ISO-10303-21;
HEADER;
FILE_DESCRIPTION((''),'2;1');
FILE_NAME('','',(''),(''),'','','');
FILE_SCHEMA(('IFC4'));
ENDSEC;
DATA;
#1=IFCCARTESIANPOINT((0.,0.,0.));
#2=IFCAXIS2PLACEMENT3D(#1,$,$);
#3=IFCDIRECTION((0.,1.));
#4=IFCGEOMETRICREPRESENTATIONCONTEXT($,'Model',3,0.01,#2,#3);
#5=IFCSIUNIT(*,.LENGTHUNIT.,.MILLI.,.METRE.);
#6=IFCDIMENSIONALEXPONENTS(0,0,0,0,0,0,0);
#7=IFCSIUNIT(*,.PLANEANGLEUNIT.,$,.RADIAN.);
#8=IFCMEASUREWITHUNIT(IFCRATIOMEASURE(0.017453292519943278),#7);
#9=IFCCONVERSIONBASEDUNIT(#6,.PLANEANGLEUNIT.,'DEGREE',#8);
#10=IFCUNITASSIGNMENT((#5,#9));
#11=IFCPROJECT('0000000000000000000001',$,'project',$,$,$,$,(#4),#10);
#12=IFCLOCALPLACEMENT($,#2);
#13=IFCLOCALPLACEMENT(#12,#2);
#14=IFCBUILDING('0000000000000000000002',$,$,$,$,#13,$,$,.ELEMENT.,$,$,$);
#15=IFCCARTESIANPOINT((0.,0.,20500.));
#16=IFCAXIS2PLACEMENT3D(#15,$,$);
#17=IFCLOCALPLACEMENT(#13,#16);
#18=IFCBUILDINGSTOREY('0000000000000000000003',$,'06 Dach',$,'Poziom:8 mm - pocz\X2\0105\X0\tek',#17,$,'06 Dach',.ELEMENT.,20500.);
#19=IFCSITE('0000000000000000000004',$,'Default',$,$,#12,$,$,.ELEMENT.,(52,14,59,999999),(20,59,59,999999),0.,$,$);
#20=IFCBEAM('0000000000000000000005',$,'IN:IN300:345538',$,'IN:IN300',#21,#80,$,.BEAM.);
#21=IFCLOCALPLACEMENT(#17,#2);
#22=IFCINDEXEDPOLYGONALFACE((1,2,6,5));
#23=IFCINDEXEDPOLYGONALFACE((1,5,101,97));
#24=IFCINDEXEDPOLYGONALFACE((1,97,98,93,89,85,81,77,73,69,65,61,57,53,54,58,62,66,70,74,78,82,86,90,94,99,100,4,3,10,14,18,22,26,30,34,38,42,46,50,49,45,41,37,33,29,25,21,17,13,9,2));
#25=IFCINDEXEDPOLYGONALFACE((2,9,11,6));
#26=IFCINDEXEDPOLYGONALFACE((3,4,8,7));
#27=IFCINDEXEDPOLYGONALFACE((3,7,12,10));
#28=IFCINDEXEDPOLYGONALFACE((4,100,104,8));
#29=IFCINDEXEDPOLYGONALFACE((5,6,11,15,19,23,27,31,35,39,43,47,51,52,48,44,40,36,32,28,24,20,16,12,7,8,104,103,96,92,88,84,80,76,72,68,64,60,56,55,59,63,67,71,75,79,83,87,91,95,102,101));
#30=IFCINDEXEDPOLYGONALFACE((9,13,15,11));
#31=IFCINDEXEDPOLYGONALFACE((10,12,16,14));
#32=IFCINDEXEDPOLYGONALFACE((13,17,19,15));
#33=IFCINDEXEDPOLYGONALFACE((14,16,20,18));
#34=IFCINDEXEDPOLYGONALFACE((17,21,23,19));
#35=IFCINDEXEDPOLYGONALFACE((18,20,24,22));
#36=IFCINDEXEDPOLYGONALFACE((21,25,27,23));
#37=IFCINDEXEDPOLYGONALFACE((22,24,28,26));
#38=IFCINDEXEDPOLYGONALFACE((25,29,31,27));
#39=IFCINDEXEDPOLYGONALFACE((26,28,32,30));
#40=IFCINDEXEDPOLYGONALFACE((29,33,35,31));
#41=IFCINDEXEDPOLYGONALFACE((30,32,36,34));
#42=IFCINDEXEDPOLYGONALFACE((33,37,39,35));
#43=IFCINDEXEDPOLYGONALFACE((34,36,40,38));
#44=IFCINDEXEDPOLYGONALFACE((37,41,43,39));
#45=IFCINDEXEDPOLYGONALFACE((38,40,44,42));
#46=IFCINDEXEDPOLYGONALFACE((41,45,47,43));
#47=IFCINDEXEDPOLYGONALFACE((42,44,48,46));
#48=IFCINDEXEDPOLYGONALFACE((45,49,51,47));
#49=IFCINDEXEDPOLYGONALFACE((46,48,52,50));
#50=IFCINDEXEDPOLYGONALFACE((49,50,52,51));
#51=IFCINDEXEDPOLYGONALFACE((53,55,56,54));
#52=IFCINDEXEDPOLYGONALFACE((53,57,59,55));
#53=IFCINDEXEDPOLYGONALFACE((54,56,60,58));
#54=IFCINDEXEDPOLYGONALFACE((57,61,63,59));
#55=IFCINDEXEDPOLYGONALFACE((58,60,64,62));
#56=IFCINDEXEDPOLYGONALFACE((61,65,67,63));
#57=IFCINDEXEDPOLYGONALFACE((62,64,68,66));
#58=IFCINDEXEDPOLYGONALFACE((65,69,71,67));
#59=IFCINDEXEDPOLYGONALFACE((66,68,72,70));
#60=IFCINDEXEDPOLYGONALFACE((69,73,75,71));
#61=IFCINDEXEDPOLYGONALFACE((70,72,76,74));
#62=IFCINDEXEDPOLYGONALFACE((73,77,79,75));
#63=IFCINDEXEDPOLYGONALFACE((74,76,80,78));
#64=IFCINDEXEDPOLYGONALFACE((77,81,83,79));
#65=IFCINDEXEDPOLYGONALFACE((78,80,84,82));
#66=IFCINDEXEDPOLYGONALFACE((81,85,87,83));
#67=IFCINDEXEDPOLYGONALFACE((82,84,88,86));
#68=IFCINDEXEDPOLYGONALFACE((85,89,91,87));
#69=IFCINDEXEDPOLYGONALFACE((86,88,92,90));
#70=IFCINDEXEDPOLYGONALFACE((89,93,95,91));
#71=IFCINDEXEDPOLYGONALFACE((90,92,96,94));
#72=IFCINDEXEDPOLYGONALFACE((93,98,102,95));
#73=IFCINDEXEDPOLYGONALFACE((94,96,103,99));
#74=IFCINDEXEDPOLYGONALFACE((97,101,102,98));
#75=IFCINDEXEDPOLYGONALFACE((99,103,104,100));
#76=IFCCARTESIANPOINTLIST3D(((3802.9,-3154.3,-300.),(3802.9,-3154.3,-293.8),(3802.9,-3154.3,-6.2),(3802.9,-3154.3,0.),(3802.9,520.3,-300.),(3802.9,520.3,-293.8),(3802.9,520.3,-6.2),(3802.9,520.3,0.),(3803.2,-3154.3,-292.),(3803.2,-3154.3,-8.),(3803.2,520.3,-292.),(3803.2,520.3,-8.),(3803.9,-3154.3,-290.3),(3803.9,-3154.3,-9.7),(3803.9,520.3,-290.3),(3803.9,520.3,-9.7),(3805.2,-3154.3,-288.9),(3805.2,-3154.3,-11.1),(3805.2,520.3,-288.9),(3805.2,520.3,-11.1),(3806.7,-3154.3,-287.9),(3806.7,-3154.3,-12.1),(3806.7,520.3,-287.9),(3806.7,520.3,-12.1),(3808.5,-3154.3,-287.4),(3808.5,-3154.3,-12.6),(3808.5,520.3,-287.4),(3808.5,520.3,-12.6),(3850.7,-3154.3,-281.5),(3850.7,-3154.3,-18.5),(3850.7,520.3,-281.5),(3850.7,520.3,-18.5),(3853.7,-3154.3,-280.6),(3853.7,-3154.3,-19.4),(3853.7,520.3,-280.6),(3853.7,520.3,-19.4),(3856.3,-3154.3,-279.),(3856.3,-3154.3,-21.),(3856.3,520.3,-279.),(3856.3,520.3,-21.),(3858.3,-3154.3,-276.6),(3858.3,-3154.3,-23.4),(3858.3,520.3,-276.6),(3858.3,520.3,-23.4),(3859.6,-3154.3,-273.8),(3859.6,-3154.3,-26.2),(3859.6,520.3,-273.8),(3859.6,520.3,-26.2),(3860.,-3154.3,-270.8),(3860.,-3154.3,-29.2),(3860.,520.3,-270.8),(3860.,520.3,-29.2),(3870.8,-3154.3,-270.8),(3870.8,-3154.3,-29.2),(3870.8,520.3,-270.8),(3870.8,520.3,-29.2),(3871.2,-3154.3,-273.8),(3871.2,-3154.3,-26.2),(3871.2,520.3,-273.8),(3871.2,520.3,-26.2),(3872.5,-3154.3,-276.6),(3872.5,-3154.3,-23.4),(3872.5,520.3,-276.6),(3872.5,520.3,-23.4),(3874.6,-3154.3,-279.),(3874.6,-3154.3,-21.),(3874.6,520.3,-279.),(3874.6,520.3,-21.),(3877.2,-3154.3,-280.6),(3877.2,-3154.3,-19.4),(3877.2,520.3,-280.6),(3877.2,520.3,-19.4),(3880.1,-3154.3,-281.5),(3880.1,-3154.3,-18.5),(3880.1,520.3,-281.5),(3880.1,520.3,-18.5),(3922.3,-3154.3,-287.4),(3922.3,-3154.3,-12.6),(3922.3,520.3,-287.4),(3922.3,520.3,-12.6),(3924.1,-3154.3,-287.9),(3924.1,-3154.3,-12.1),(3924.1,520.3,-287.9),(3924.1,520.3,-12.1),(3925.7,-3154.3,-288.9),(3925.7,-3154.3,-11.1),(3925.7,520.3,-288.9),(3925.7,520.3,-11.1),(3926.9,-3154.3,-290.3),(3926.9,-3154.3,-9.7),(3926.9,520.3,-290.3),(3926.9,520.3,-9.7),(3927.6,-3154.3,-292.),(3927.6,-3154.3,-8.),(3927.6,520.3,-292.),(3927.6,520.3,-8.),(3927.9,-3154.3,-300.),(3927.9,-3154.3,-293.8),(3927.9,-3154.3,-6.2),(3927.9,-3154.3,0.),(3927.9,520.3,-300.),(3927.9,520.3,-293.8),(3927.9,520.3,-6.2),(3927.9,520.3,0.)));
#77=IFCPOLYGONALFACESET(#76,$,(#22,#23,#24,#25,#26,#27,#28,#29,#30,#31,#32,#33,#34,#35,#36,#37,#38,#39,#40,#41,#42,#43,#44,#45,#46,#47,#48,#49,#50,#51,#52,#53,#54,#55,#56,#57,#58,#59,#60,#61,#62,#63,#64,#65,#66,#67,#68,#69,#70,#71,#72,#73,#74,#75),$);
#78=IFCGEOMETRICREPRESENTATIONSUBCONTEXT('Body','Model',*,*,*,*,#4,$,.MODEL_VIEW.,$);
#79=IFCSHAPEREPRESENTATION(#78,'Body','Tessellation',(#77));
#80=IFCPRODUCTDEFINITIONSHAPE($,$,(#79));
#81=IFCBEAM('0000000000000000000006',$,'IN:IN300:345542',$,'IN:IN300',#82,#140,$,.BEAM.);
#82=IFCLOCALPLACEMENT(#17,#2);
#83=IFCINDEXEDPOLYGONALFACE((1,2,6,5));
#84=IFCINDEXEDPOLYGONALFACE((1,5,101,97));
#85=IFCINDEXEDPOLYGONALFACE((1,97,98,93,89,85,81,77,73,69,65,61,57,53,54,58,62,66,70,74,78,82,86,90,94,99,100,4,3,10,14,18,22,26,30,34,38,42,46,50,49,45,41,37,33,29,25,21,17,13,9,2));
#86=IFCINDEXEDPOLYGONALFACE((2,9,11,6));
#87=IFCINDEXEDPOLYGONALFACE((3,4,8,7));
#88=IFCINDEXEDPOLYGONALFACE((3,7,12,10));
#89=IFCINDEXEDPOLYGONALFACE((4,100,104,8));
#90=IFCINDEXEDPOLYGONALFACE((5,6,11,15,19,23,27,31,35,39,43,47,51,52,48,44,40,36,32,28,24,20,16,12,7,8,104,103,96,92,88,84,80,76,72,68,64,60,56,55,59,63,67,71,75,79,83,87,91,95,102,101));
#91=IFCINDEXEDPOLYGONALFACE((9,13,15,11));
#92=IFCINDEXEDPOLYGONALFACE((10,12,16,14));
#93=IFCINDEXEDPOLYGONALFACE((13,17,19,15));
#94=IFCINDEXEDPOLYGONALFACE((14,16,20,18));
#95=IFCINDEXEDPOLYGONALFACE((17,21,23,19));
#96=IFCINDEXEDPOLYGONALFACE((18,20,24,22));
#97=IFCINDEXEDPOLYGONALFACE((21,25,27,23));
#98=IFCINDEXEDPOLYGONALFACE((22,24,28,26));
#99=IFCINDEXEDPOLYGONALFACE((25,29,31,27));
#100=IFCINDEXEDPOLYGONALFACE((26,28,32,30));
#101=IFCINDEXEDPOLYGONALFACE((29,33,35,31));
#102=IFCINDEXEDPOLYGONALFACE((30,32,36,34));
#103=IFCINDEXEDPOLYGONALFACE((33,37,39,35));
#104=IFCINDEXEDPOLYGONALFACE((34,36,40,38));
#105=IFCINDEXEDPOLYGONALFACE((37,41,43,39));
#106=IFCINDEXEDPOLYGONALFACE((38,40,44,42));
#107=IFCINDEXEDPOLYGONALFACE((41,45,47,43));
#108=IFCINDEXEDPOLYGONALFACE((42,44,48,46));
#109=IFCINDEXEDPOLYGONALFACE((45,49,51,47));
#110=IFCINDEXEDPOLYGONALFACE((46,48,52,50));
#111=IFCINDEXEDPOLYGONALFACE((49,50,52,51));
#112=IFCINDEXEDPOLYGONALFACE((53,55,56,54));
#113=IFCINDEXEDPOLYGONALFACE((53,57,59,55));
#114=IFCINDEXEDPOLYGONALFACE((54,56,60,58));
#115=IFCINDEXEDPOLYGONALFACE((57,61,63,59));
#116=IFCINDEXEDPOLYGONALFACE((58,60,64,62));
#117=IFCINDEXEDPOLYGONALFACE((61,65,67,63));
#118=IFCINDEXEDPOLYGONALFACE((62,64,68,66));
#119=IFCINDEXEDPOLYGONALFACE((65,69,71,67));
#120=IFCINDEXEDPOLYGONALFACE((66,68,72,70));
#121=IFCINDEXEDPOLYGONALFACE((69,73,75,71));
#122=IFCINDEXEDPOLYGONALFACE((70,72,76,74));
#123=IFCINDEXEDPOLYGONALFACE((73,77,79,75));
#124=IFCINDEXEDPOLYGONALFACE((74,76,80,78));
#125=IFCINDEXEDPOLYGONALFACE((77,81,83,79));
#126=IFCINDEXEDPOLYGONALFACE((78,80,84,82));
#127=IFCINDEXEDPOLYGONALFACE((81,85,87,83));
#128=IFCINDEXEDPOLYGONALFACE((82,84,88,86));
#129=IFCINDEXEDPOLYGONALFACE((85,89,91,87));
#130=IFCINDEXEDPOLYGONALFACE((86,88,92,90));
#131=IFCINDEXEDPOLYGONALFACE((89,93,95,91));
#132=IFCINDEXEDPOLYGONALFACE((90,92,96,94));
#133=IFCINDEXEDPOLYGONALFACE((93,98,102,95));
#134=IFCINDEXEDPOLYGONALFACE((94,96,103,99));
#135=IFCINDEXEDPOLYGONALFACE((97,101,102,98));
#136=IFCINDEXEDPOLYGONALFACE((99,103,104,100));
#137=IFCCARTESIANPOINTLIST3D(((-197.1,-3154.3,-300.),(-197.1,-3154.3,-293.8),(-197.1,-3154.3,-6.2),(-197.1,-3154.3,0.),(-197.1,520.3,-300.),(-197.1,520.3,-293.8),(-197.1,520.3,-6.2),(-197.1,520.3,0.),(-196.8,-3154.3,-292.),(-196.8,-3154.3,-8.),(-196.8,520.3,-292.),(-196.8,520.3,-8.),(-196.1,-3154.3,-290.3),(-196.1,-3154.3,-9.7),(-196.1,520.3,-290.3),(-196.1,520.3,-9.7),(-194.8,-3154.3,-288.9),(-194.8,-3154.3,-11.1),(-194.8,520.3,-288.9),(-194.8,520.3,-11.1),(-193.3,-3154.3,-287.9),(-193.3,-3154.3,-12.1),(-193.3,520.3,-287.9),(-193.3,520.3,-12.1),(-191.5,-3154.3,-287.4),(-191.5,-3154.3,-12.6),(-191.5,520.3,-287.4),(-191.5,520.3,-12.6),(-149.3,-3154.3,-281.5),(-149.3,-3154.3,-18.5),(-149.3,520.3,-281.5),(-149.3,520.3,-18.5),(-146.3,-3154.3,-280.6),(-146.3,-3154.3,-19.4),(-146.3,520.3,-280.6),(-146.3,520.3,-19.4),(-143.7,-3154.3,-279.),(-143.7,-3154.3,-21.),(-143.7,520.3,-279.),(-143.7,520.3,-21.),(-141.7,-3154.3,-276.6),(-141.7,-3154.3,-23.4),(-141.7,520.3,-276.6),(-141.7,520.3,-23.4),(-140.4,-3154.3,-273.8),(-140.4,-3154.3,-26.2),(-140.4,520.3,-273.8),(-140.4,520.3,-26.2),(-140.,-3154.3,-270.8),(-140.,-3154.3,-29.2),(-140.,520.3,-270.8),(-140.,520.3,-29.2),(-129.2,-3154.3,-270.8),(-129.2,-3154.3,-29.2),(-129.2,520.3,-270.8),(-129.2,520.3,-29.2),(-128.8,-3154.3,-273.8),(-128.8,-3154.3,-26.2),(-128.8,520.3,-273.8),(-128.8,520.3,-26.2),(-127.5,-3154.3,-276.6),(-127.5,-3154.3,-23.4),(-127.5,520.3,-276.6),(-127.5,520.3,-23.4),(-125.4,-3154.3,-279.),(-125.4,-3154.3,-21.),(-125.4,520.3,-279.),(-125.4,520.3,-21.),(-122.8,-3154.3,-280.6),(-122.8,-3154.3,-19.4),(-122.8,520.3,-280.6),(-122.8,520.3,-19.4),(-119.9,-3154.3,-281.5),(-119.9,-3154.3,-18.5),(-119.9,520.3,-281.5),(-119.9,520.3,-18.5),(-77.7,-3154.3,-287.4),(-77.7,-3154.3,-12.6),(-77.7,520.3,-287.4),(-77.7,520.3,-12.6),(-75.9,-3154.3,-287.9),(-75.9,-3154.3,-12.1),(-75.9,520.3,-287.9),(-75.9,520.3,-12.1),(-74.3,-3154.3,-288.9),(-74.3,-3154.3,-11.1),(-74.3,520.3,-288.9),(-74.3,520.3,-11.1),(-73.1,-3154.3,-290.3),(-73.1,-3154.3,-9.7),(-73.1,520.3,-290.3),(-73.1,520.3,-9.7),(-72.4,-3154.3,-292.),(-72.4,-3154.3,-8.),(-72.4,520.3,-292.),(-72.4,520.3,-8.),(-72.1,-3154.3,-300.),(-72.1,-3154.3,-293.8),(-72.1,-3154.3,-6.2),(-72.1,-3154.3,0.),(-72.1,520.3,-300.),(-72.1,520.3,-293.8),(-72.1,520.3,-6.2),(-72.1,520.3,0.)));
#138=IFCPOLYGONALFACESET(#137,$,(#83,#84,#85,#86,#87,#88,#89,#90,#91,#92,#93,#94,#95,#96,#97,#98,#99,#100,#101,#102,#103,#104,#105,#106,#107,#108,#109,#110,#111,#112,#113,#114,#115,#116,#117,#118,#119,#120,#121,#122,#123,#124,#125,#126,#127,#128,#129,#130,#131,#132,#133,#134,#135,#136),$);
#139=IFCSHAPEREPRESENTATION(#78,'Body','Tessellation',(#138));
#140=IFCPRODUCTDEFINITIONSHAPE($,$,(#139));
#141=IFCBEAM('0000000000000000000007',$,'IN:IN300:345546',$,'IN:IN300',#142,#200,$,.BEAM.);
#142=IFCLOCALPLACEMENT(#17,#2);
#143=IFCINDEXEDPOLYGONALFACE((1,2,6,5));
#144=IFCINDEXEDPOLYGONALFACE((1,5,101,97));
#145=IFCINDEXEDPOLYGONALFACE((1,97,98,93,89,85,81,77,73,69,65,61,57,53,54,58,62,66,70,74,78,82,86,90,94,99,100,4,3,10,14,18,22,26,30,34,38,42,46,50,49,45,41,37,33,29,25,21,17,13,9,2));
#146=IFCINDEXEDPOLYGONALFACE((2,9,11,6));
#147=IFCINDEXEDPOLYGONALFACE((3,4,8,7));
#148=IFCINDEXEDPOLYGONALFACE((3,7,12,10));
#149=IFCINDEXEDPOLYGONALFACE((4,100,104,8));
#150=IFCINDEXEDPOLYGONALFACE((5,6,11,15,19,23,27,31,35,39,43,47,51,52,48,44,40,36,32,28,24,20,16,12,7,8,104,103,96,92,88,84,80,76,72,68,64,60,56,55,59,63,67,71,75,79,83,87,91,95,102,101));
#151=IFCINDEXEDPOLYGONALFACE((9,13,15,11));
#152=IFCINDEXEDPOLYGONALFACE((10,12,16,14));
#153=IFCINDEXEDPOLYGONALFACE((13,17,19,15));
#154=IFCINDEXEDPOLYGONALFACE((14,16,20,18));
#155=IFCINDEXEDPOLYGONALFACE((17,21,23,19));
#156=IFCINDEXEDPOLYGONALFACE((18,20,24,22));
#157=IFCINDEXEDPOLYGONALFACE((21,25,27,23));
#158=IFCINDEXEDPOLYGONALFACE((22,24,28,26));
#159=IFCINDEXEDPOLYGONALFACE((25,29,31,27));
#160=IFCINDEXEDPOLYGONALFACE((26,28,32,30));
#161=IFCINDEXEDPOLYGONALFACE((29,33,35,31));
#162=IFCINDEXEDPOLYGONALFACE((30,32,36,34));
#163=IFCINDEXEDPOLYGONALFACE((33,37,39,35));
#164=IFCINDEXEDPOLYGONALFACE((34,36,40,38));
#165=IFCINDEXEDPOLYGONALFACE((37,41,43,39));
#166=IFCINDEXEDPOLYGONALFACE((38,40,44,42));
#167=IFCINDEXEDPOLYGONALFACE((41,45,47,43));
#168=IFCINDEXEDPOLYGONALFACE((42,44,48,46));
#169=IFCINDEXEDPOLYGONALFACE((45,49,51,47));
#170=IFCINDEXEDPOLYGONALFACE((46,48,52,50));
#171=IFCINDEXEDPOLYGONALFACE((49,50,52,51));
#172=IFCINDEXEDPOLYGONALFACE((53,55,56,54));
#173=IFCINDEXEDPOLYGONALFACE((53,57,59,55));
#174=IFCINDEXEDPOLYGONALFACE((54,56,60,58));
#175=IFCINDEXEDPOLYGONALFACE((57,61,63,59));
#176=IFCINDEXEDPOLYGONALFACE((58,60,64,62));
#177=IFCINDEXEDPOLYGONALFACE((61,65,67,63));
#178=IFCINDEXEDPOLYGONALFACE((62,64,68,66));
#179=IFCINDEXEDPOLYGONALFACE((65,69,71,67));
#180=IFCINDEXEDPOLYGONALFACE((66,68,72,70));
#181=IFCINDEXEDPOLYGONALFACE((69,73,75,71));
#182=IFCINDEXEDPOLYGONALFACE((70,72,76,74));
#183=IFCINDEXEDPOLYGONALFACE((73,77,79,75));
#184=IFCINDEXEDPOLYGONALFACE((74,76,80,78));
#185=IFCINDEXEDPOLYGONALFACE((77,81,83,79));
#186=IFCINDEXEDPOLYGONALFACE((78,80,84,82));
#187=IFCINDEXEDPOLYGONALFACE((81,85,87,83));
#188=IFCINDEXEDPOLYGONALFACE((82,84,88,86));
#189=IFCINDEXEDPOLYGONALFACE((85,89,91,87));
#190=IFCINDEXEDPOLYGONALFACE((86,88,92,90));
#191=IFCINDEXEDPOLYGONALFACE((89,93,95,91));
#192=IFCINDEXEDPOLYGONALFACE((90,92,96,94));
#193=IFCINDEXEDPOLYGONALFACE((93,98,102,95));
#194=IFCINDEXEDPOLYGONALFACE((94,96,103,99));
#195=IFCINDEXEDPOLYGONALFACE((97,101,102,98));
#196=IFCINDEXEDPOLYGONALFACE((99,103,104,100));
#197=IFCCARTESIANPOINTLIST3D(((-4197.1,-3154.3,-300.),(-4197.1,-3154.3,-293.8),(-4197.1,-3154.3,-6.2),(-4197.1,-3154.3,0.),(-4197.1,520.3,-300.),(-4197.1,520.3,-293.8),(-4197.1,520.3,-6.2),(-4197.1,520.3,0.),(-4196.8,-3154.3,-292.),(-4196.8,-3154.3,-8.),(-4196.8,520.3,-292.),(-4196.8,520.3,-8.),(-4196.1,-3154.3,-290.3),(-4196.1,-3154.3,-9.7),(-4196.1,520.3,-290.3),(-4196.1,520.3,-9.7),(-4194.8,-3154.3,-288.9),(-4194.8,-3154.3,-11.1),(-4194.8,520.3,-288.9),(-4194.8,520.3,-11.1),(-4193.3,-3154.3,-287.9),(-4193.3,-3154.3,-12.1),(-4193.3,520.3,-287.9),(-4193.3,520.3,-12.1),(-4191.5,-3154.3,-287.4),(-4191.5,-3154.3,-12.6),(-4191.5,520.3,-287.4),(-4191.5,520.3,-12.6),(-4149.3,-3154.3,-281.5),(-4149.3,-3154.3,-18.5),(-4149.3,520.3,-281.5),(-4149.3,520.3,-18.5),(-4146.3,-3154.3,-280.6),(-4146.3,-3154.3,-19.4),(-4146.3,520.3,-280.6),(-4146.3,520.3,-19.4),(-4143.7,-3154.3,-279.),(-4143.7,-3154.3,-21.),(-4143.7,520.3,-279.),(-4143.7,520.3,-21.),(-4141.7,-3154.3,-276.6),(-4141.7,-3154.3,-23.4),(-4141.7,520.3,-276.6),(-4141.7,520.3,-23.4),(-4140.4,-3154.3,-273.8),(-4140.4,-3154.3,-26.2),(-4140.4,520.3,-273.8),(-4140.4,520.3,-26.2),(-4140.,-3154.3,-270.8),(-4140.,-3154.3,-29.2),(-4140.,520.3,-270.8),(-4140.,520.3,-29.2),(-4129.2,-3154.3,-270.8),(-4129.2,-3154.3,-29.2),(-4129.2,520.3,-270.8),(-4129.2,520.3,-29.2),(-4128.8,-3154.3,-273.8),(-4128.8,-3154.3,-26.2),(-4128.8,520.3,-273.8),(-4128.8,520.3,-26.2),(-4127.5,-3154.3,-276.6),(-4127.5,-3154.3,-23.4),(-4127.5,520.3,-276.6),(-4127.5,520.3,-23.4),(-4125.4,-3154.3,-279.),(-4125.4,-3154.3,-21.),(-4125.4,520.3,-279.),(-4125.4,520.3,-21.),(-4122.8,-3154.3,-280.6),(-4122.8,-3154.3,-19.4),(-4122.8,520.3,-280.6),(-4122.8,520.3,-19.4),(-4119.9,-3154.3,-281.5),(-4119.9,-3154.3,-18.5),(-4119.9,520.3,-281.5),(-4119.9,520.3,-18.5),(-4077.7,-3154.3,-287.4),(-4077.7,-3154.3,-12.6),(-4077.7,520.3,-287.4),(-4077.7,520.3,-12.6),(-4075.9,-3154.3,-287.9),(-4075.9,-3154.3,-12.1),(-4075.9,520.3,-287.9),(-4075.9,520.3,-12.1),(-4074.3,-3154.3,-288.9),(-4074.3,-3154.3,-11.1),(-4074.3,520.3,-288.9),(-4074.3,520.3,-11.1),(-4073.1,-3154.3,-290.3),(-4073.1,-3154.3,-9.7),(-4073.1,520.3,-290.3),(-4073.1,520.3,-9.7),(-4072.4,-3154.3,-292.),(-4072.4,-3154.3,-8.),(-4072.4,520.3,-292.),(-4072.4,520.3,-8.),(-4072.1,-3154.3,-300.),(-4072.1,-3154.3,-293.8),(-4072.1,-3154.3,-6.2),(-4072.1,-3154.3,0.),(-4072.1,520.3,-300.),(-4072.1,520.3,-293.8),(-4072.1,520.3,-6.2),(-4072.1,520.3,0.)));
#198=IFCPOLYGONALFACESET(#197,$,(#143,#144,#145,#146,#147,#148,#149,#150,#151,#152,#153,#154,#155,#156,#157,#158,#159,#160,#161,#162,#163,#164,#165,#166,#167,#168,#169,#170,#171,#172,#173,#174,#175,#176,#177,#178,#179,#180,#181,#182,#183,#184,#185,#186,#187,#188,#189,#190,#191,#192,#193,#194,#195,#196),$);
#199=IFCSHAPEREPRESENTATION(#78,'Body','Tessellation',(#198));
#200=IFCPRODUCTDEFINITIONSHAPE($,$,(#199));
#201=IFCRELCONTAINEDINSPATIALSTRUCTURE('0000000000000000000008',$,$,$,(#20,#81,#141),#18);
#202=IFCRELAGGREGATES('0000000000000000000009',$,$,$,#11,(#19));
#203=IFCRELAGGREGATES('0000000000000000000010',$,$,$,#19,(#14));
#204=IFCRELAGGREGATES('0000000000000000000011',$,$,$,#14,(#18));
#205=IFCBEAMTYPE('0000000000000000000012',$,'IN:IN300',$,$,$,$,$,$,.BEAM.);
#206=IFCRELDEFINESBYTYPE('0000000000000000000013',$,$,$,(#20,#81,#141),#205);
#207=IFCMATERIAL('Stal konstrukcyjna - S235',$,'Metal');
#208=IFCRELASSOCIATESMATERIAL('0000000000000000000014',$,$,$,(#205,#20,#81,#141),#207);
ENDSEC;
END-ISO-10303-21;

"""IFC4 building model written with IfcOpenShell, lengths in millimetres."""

from ifc_helpers import new_model, entity, si_unit, converted_unit, direction, frame, origin, place, context, subcontext, project, spatial, line, arc, indexed_curve, outline, extrude, source, transform, mapped, material, type_object, type_shapes, element, save


model = new_model("IFC4")

# Units and contexts
model_context = context("Model", 3, precision=0.01, world=origin(), true_north=direction((0.0, 1.0)))
body_context = subcontext(model_context, "Body", "Model", "MODEL_VIEW")
ifc_project = project(units=[si_unit("LENGTHUNIT", "METRE", prefix="MILLI"), converted_unit("PLANEANGLEUNIT", "DEGREE", entity("IfcRatioMeasure", 0.017453292519943278), si_unit("PLANEANGLEUNIT", "RADIAN"), dimensions=[0, 0, 0, 0, 0, 0, 0])], contexts=[model_context])

# Site, building, storey
site_placement = place(None, origin())
site = spatial("IfcSite", under=ifc_project, at=site_placement, Name="Default", CompositionType="ELEMENT", RefLatitude=(52, 14, 59, 999999), RefLongitude=(20, 59, 59, 999999), RefElevation=0.0)
building_placement = place(site_placement, origin())
building = spatial("IfcBuilding", under=site, at=building_placement, CompositionType="ELEMENT")
storey_placement = place(building_placement, frame((0.0, 0.0, 20500.0)))
storey = spatial("IfcBuildingStorey", under=building, at=storey_placement, Name="06 Dach", ObjectType="Poziom:8 mm - początek", LongName="06 Dach", CompositionType="ELEMENT", Elevation=20500.0)

# Beams
ifc_material_1 = material(Name="Stal konstrukcyjna - S235", Category="Metal")
beam_type_1 = type_object("IfcBeamType", Name="IN:IN300", PredefinedType="BEAM", material=ifc_material_1)
shared_shape_1 = source(origin(), body_context, "Body", "SweptSolid", [
    extrude(outline(indexed_curve([(143.8, -62.5), (150.0, -62.5), (150.0, 62.5), (143.8, 62.5), (139.6, 60.9), (137.4, 56.9), (131.5, 14.7), (127.9, 8.1), (120.8, 5.4), (-120.8, 5.4), (-127.9, 8.1), (-131.5, 14.7), (-137.4, 56.9), (-139.6, 60.9), (-143.8, 62.5), (-150.0, 62.5), (-150.0, -62.5), (-143.8, -62.5), (-139.6, -60.9), (-137.4, -56.9), (-131.5, -14.7), (-127.9, -8.1), (-120.8, -5.4), (120.8, -5.4), (127.9, -8.1), (131.5, -14.7), (137.4, -56.9), (139.6, -60.9)], segments=[line(1, 2, 3, 4), arc(4, 5, 6), line(6, 7), arc(7, 8, 9), line(9, 10), arc(10, 11, 12), line(12, 13), arc(13, 14, 15), line(15, 16, 17, 18), arc(18, 19, 20), line(20, 21), arc(21, 22, 23), line(23, 24), arc(24, 25, 26), line(26, 27), arc(27, 28, 1)], self_intersect=False)), frame((-1837.3, 0.0, 0.0), z_axis=(1.0, 0.0, 0.0), x_axis=(0.0, 0.0, -1.0)), (0.0, 0.0, 1.0), 3674.6),
])
type_shapes(beam_type_1, [shared_shape_1])
for number, where, z_axis, x_axis, name in (
    (1, (3865.4, -1317.0, -150.0), (0.0, 0.0, 1.0), (0.0, -1.0, 0.0), "IN:IN300:345538"),
    (2, (-134.6, -1317.0, -150.0), (0.0, 0.0, 1.0), (0.0, -1.0, 0.0), "IN:IN300:345542"),
    (3, (-4134.6, -1317.0, -150.0), (0.0, 0.0, 1.0), (0.0, -1.0, 0.0), "IN:IN300:345546"),
):
    element("IfcBeam", number, at=place(storey_placement, frame(where, z_axis=z_axis, x_axis=x_axis)), inside=storey, type_object=beam_type_1, material=ifc_material_1, Name=name, ObjectType="IN:IN300", PredefinedType="BEAM", context=body_context, shape_type="MappedRepresentation", body=[
        mapped(shared_shape_1, transform((0.0, 0.0, 0.0), scale=1.0)),
    ])

save(model, "model.ifc")
